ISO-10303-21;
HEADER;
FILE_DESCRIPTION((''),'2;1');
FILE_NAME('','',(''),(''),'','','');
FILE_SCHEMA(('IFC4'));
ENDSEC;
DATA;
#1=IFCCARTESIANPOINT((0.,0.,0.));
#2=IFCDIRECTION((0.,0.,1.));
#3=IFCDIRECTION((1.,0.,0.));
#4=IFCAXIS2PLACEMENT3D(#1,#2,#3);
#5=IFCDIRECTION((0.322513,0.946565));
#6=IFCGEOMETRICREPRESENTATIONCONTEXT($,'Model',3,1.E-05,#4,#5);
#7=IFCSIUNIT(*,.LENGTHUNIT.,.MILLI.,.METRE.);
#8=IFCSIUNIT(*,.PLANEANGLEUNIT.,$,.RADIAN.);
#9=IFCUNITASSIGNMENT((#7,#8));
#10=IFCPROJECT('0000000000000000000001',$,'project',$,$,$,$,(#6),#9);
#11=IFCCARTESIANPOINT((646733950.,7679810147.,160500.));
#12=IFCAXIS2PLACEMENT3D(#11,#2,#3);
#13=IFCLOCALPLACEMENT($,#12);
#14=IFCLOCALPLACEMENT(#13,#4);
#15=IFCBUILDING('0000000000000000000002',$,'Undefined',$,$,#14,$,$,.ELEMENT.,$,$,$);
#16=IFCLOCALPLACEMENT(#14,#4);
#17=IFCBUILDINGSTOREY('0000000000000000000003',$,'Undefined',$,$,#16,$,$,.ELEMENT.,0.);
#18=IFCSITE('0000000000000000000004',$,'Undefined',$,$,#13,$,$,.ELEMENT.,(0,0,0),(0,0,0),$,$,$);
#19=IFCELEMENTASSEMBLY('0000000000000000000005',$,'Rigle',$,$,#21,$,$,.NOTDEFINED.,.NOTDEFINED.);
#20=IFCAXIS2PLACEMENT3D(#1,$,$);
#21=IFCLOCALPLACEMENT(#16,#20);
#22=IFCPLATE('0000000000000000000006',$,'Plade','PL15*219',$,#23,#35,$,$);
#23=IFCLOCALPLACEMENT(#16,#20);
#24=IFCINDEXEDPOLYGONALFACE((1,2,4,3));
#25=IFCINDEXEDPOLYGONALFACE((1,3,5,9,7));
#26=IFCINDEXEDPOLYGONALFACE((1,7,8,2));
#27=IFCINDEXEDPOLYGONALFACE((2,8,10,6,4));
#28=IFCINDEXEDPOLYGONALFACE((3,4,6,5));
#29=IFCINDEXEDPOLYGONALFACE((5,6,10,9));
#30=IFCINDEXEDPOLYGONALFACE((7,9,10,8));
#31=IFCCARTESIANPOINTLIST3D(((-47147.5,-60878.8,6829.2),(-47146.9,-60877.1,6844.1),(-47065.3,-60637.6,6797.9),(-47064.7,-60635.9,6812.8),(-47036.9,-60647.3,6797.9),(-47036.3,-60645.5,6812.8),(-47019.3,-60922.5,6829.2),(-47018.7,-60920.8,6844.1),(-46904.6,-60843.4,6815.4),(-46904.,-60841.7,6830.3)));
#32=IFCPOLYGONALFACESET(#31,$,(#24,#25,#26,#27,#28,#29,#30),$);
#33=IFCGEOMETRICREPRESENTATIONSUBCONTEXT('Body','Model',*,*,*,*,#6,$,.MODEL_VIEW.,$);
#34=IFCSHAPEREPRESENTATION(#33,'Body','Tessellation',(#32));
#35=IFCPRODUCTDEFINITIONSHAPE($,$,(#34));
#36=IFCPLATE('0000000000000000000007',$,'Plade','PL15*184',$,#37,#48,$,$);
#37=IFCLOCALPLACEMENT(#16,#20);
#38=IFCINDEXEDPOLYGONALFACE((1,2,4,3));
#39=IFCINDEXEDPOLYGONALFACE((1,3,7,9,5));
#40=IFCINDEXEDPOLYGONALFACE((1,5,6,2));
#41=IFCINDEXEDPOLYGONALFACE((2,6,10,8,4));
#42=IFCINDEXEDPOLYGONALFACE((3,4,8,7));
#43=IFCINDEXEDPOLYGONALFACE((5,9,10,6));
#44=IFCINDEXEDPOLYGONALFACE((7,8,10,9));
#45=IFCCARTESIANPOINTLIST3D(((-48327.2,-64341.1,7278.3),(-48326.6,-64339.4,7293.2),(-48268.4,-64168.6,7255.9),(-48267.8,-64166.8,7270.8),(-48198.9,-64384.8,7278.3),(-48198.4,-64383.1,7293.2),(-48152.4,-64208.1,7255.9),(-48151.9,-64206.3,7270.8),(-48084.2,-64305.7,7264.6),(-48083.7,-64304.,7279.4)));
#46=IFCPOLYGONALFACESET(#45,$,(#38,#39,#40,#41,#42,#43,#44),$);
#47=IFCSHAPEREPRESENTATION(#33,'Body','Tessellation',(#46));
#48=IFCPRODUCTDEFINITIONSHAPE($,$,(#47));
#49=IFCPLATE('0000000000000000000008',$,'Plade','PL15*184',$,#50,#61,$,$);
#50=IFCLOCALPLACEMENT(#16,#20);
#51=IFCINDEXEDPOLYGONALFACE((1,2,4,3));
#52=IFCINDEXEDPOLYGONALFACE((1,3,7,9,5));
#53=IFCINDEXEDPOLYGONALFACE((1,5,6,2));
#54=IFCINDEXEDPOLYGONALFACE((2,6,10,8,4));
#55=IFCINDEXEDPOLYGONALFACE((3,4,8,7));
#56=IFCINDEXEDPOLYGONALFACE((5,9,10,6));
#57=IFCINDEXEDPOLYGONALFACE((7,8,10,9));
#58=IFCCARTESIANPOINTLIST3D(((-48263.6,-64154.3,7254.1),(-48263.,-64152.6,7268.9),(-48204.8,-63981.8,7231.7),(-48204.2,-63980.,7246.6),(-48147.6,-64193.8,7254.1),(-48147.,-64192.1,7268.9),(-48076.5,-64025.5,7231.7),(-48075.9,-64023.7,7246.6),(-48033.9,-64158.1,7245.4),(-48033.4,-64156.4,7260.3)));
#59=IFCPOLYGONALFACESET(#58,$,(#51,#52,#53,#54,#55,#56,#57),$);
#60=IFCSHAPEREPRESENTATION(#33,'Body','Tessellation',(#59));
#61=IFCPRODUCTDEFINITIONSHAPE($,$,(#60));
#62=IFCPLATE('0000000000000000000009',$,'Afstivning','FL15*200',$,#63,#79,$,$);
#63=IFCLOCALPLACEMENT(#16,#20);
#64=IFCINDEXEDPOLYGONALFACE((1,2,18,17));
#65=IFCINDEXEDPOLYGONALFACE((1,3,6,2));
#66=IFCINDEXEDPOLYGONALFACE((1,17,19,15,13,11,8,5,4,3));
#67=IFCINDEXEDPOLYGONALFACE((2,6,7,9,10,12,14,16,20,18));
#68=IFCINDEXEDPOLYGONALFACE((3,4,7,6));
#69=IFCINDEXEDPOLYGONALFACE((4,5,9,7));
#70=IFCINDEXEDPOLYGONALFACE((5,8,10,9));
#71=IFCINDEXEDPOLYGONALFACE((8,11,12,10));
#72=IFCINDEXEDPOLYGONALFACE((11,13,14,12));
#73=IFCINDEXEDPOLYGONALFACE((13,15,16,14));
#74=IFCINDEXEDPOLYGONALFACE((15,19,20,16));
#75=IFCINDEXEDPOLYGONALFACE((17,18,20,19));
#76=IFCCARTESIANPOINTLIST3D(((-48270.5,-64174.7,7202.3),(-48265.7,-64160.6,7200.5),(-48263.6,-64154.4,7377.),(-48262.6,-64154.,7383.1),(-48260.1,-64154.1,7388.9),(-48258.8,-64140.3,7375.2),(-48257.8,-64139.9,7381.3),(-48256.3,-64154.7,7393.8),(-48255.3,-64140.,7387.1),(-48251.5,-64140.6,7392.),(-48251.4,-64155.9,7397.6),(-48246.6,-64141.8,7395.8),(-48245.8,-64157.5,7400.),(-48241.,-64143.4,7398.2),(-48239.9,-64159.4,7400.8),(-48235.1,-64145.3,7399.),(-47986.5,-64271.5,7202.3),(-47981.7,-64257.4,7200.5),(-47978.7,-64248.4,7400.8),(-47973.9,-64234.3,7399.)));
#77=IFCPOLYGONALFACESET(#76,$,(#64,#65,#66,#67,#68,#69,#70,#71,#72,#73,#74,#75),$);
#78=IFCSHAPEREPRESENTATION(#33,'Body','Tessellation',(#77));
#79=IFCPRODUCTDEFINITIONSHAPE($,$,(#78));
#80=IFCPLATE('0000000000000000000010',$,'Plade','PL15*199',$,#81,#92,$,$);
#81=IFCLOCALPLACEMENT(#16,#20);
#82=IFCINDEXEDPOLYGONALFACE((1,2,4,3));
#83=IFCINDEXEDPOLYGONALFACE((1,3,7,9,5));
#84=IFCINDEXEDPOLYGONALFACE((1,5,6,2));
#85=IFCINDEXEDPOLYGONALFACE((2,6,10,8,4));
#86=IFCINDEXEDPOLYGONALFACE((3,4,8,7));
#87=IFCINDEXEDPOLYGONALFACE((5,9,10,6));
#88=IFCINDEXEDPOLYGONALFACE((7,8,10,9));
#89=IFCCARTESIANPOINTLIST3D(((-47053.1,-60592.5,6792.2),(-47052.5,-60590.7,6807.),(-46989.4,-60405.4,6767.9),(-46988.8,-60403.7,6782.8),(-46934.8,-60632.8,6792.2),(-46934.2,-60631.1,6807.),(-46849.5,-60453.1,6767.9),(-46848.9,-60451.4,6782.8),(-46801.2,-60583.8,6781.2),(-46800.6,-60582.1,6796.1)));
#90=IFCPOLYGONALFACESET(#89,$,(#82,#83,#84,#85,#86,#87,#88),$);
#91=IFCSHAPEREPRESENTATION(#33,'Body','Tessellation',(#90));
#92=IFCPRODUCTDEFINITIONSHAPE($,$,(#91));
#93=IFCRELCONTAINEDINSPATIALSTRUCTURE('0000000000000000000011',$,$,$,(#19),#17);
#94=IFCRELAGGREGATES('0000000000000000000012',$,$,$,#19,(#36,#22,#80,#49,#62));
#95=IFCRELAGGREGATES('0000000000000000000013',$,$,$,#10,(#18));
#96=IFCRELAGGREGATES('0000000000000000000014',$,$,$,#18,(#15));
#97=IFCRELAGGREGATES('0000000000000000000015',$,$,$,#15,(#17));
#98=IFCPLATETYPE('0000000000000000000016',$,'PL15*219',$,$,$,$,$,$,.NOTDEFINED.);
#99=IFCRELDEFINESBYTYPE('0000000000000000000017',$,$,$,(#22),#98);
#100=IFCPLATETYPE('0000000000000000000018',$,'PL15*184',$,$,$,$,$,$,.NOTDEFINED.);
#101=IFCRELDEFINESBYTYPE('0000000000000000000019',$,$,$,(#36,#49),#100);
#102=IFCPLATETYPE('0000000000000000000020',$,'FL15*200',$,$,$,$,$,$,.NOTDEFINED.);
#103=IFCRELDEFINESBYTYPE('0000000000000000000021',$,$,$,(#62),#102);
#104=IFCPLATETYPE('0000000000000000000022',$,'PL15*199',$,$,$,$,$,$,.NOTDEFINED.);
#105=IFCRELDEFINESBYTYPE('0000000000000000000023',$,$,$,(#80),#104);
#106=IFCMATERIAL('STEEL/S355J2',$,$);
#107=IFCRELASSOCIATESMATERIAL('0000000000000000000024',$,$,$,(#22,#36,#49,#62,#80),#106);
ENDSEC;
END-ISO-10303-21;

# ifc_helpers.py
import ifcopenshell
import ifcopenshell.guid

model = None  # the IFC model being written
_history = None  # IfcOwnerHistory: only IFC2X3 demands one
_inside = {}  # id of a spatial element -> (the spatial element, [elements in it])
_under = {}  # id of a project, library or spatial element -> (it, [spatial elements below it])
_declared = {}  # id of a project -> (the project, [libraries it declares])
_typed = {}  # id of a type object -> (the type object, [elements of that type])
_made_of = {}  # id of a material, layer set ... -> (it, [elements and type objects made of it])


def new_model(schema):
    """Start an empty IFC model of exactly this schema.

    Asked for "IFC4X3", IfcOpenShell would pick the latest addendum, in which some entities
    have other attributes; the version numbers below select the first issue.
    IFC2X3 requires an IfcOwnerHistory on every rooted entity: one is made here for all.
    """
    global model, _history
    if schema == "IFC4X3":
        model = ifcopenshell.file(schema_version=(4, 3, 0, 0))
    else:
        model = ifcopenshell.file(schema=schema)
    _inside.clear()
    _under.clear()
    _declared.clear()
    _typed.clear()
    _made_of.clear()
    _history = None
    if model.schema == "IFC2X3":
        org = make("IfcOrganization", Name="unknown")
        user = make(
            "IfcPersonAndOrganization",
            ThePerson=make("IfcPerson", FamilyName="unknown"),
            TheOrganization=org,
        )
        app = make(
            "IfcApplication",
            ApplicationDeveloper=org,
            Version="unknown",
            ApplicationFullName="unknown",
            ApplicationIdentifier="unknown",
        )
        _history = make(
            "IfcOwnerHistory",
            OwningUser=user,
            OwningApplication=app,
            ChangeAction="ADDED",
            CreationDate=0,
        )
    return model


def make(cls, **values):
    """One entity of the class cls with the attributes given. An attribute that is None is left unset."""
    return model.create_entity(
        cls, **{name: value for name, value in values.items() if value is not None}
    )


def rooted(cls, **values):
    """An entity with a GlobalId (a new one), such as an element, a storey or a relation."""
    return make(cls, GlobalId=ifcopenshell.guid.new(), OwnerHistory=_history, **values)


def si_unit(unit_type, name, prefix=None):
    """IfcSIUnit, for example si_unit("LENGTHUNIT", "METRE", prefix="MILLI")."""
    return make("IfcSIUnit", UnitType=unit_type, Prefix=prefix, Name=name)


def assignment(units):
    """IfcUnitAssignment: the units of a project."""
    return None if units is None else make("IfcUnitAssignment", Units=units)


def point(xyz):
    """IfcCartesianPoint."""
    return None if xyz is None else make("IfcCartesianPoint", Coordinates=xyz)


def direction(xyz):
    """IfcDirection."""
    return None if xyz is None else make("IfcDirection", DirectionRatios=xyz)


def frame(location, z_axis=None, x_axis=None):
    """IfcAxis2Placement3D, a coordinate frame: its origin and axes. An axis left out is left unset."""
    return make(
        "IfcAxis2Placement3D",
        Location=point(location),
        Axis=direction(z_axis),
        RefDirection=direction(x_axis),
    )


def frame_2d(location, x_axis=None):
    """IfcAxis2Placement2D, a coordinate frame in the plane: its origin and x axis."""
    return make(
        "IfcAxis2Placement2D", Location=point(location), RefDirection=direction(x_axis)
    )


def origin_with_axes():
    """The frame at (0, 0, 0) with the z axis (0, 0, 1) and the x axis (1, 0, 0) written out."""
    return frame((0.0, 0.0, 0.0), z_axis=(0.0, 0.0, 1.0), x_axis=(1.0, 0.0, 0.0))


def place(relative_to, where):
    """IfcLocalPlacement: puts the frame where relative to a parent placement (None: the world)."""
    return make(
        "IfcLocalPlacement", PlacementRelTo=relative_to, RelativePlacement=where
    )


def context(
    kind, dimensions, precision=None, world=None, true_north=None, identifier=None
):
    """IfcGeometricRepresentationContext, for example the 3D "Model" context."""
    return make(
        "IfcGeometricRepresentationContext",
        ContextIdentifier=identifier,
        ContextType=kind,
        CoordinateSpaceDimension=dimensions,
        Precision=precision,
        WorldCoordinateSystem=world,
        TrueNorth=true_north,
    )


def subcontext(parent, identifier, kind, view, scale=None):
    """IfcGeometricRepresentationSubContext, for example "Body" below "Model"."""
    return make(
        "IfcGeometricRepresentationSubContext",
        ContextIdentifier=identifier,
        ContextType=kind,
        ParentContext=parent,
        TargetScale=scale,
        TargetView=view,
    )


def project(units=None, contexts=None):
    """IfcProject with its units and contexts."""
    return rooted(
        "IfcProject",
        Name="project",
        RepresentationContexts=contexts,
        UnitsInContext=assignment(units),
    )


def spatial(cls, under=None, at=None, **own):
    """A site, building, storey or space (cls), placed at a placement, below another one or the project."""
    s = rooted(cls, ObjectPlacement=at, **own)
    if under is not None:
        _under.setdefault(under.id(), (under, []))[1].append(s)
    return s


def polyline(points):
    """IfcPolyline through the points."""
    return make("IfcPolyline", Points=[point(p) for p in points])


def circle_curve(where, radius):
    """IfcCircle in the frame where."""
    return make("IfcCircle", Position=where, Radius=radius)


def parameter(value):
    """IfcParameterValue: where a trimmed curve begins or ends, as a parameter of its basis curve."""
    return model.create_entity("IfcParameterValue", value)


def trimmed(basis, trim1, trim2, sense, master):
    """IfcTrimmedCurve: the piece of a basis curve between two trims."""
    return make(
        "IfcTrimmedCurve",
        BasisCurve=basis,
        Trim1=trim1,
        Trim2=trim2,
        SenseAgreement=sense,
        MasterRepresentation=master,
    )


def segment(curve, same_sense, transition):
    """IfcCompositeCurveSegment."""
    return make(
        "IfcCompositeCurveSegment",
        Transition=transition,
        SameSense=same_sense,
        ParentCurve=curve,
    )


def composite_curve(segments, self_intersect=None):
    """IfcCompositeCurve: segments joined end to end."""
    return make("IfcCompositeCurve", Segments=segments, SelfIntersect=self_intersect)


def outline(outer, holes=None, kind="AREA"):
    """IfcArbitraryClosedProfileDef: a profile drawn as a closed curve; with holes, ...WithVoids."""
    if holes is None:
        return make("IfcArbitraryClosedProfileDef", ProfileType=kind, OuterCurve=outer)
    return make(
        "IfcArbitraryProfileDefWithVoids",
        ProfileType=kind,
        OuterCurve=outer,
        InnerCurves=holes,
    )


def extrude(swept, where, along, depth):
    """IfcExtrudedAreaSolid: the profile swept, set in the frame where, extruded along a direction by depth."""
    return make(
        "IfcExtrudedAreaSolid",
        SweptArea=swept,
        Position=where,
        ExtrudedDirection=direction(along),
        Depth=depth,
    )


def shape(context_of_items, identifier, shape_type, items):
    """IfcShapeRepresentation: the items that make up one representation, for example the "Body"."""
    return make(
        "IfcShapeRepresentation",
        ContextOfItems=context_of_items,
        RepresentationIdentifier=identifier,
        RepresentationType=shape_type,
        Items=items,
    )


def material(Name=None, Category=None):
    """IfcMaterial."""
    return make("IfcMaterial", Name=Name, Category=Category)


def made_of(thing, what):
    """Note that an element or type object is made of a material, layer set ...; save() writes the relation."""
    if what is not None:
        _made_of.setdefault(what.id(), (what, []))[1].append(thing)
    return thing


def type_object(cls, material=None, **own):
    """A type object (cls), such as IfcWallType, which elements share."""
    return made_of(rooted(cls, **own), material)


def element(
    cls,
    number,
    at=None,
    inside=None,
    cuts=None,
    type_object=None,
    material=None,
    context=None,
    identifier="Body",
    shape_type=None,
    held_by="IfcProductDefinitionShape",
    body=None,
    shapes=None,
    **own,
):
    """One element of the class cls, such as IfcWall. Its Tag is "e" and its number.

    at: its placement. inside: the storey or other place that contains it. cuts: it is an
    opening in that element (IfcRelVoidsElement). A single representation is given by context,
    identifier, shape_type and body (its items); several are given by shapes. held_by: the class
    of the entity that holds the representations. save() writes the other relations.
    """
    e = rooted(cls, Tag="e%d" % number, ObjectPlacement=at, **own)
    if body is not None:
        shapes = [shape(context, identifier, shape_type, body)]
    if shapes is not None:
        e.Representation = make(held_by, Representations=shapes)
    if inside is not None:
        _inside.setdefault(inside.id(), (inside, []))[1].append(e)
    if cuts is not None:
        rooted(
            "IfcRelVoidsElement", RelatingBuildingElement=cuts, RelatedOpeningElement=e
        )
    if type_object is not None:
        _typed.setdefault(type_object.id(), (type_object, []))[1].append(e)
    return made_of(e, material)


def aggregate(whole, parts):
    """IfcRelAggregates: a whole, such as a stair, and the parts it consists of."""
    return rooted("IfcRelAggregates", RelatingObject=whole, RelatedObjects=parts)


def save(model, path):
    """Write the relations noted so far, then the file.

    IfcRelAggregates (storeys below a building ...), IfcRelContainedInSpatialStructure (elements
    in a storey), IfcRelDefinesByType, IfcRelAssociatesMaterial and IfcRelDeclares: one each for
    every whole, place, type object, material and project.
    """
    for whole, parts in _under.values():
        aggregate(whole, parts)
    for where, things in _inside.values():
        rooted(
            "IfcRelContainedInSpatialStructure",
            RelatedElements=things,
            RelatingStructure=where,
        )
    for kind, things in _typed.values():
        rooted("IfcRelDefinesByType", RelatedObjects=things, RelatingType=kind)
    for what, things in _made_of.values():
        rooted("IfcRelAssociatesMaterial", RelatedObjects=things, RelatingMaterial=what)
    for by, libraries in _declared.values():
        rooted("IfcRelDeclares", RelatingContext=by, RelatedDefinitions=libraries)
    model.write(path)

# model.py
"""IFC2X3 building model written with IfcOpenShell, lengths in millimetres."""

from ifc_helpers import new_model, si_unit, direction, frame, frame_2d, origin_with_axes, place, context, subcontext, project, spatial, polyline, circle_curve, parameter, trimmed, segment, composite_curve, outline, extrude, material, type_object, element, aggregate, save


model = new_model("IFC2X3")

# Units and contexts
model_context = context("Model", 3, precision=1e-05, world=origin_with_axes(), true_north=direction((0.322513, 0.946565)))
body_context = subcontext(model_context, "Body", "Model", "MODEL_VIEW")
ifc_project = project(units=[si_unit("LENGTHUNIT", "METRE", prefix="MILLI"), si_unit("PLANEANGLEUNIT", "RADIAN")], contexts=[model_context])

# Site, building, storey
site_placement = place(None, frame((646733950.0, 7679810147.0, 160500.0), z_axis=(0.0, 0.0, 1.0), x_axis=(1.0, 0.0, 0.0)))
site = spatial("IfcSite", under=ifc_project, at=site_placement, Name="Undefined", CompositionType="ELEMENT", RefLatitude=(0, 0, 0), RefLongitude=(0, 0, 0))
building_placement = place(site_placement, origin_with_axes())
building = spatial("IfcBuilding", under=site, at=building_placement, Name="Undefined", CompositionType="ELEMENT")
storey_placement = place(building_placement, origin_with_axes())
storey = spatial("IfcBuildingStorey", under=building, at=storey_placement, Name="Undefined", CompositionType="ELEMENT", Elevation=0.0)

# Shared definitions
ifc_material_1 = material(Name="STEEL/S355J2")

# Element assembly
assembly_1_placement = place(storey_placement, origin_with_axes())
assembly_1 = element("IfcElementAssembly", 1, at=assembly_1_placement, inside=storey, Name="Rigle", AssemblyPlace="NOTDEFINED", PredefinedType="NOTDEFINED")

# Plates
plate_type_1 = type_object("IfcPlateType", Name="PL15*219", PredefinedType="NOTDEFINED")
plate_1_placement = place(assembly_1_placement, frame((-47065.0, -60636.7, 6805.3), z_axis=(0.039304, 0.115357, 0.992546), x_axis=(-0.320109, -0.93951, 0.121869)))
plate_1 = element("IfcPlate", 2, at=plate_1_placement, type_object=plate_type_1, material=ifc_material_1, Name="Plade", Description="PL15*219", context=body_context, shape_type="SweptSolid", body=[
    extrude(outline(polyline([(0.0, 0.0), (256.8, 0.0), (256.8, 135.5), (144.1, 218.6), (0.0, 30.0), (0.0, 0.0)])), frame((0.0, 0.0, -7.5), z_axis=(0.0, 0.0, 1.0), x_axis=(1.0, 0.0, 0.0)), (0.0, 0.0, 1.0), 15.0),
])
plate_type_2 = type_object("IfcPlateType", Name="PL15*184", PredefinedType="NOTDEFINED")
plate_2_placement = place(assembly_1_placement, frame((-48268.1, -64167.7, 7263.3), z_axis=(0.039304, 0.115357, 0.992546), x_axis=(-0.320109, -0.93951, 0.121869)))
plate_2 = element("IfcPlate", 3, at=plate_2_placement, type_object=plate_type_2, material=ifc_material_1, Name="Plade", Description="PL15*184", context=body_context, shape_type="SweptSolid", body=[
    extrude(outline(polyline([(0.0, 0.0), (183.7, 0.0), (183.7, 135.5), (71.0, 218.6), (0.0, 122.5), (0.0, 0.0)])), frame((0.0, 0.0, -7.5), z_axis=(0.0, 0.0, 1.0), x_axis=(1.0, 0.0, 0.0)), (0.0, 0.0, 1.0), 15.0),
])
plate_3_placement = place(assembly_1_placement, frame((-48204.5, -63980.9, 7239.1), z_axis=(0.039304, 0.115357, 0.992546), x_axis=(-0.320109, -0.93951, 0.121869)))
plate_3 = element("IfcPlate", 4, at=plate_3_placement, type_object=plate_type_2, material=ifc_material_1, Name="Plade", Description="PL15*184", context=body_context, shape_type="SweptSolid", body=[
    extrude(outline(polyline([(0.0, 0.0), (183.7, 0.0), (183.7, 122.5), (112.7, 218.6), (0.0, 135.5), (0.0, 0.0)])), frame((0.0, 0.0, -7.5), z_axis=(0.0, 0.0, 1.0), x_axis=(1.0, 0.0, 0.0)), (0.0, 0.0, 1.0), 15.0),
])
plate_type_3 = type_object("IfcPlateType", Name="FL15*200", PredefinedType="NOTDEFINED")
plate_4_placement = place(assembly_1_placement, frame((-48268.1, -64167.7, 7201.4), z_axis=(-0.320109, -0.93951, 0.121869), x_axis=(0.946565, -0.322513, 0.0)))
plate_4 = element("IfcPlate", 5, at=plate_4_placement, type_object=plate_type_3, material=ifc_material_1, Name="Afstivning", Description="FL15*200", context=body_context, shape_type="SweptSolid", body=[
    extrude(outline(composite_curve([segment(polyline([(0.0, 0.0), (300.0, 0.0), (300.0, 200.0), (24.0, 200.0)]), True, "CONTINUOUS"), segment(trimmed(circle_curve(frame_2d((24.0, 176.0), x_axis=(0.0, 1.0)), 24.0), [parameter(0.0)], [parameter(1.570796)], True, "PARAMETER"), True, "CONTINUOUS"), segment(polyline([(0.0, 176.0), (0.0, 0.0)]), True, "CONTINUOUS")], self_intersect=True)), frame((0.0, 0.0, -7.5), z_axis=(0.0, 0.0, 1.0), x_axis=(1.0, 0.0, 0.0)), (0.0, 0.0, 1.0), 15.0),
])
plate_type_4 = type_object("IfcPlateType", Name="PL15*199", PredefinedType="NOTDEFINED")
plate_5_placement = place(assembly_1_placement, frame((-46989.1, -60404.6, 6775.3), z_axis=(0.039304, 0.115357, 0.992546), x_axis=(-0.320109, -0.93951, 0.121869)))
plate_5 = element("IfcPlate", 6, at=plate_5_placement, type_object=plate_type_4, material=ifc_material_1, Name="Plade", Description="PL15*199", context=body_context, shape_type="SweptSolid", body=[
    extrude(outline(polyline([(0.0, 0.0), (199.1, 0.0), (199.1, 125.0), (109.0, 235.7), (0.0, 147.8), (0.0, 0.0)])), frame((0.0, 0.0, -7.5), z_axis=(0.0, 0.0, 1.0), x_axis=(1.0, 0.0, 0.0)), (0.0, 0.0, 1.0), 15.0),
])

aggregate(assembly_1, [plate_2, plate_1, plate_5, plate_3, plate_4])

save(model, "model.ifc")
